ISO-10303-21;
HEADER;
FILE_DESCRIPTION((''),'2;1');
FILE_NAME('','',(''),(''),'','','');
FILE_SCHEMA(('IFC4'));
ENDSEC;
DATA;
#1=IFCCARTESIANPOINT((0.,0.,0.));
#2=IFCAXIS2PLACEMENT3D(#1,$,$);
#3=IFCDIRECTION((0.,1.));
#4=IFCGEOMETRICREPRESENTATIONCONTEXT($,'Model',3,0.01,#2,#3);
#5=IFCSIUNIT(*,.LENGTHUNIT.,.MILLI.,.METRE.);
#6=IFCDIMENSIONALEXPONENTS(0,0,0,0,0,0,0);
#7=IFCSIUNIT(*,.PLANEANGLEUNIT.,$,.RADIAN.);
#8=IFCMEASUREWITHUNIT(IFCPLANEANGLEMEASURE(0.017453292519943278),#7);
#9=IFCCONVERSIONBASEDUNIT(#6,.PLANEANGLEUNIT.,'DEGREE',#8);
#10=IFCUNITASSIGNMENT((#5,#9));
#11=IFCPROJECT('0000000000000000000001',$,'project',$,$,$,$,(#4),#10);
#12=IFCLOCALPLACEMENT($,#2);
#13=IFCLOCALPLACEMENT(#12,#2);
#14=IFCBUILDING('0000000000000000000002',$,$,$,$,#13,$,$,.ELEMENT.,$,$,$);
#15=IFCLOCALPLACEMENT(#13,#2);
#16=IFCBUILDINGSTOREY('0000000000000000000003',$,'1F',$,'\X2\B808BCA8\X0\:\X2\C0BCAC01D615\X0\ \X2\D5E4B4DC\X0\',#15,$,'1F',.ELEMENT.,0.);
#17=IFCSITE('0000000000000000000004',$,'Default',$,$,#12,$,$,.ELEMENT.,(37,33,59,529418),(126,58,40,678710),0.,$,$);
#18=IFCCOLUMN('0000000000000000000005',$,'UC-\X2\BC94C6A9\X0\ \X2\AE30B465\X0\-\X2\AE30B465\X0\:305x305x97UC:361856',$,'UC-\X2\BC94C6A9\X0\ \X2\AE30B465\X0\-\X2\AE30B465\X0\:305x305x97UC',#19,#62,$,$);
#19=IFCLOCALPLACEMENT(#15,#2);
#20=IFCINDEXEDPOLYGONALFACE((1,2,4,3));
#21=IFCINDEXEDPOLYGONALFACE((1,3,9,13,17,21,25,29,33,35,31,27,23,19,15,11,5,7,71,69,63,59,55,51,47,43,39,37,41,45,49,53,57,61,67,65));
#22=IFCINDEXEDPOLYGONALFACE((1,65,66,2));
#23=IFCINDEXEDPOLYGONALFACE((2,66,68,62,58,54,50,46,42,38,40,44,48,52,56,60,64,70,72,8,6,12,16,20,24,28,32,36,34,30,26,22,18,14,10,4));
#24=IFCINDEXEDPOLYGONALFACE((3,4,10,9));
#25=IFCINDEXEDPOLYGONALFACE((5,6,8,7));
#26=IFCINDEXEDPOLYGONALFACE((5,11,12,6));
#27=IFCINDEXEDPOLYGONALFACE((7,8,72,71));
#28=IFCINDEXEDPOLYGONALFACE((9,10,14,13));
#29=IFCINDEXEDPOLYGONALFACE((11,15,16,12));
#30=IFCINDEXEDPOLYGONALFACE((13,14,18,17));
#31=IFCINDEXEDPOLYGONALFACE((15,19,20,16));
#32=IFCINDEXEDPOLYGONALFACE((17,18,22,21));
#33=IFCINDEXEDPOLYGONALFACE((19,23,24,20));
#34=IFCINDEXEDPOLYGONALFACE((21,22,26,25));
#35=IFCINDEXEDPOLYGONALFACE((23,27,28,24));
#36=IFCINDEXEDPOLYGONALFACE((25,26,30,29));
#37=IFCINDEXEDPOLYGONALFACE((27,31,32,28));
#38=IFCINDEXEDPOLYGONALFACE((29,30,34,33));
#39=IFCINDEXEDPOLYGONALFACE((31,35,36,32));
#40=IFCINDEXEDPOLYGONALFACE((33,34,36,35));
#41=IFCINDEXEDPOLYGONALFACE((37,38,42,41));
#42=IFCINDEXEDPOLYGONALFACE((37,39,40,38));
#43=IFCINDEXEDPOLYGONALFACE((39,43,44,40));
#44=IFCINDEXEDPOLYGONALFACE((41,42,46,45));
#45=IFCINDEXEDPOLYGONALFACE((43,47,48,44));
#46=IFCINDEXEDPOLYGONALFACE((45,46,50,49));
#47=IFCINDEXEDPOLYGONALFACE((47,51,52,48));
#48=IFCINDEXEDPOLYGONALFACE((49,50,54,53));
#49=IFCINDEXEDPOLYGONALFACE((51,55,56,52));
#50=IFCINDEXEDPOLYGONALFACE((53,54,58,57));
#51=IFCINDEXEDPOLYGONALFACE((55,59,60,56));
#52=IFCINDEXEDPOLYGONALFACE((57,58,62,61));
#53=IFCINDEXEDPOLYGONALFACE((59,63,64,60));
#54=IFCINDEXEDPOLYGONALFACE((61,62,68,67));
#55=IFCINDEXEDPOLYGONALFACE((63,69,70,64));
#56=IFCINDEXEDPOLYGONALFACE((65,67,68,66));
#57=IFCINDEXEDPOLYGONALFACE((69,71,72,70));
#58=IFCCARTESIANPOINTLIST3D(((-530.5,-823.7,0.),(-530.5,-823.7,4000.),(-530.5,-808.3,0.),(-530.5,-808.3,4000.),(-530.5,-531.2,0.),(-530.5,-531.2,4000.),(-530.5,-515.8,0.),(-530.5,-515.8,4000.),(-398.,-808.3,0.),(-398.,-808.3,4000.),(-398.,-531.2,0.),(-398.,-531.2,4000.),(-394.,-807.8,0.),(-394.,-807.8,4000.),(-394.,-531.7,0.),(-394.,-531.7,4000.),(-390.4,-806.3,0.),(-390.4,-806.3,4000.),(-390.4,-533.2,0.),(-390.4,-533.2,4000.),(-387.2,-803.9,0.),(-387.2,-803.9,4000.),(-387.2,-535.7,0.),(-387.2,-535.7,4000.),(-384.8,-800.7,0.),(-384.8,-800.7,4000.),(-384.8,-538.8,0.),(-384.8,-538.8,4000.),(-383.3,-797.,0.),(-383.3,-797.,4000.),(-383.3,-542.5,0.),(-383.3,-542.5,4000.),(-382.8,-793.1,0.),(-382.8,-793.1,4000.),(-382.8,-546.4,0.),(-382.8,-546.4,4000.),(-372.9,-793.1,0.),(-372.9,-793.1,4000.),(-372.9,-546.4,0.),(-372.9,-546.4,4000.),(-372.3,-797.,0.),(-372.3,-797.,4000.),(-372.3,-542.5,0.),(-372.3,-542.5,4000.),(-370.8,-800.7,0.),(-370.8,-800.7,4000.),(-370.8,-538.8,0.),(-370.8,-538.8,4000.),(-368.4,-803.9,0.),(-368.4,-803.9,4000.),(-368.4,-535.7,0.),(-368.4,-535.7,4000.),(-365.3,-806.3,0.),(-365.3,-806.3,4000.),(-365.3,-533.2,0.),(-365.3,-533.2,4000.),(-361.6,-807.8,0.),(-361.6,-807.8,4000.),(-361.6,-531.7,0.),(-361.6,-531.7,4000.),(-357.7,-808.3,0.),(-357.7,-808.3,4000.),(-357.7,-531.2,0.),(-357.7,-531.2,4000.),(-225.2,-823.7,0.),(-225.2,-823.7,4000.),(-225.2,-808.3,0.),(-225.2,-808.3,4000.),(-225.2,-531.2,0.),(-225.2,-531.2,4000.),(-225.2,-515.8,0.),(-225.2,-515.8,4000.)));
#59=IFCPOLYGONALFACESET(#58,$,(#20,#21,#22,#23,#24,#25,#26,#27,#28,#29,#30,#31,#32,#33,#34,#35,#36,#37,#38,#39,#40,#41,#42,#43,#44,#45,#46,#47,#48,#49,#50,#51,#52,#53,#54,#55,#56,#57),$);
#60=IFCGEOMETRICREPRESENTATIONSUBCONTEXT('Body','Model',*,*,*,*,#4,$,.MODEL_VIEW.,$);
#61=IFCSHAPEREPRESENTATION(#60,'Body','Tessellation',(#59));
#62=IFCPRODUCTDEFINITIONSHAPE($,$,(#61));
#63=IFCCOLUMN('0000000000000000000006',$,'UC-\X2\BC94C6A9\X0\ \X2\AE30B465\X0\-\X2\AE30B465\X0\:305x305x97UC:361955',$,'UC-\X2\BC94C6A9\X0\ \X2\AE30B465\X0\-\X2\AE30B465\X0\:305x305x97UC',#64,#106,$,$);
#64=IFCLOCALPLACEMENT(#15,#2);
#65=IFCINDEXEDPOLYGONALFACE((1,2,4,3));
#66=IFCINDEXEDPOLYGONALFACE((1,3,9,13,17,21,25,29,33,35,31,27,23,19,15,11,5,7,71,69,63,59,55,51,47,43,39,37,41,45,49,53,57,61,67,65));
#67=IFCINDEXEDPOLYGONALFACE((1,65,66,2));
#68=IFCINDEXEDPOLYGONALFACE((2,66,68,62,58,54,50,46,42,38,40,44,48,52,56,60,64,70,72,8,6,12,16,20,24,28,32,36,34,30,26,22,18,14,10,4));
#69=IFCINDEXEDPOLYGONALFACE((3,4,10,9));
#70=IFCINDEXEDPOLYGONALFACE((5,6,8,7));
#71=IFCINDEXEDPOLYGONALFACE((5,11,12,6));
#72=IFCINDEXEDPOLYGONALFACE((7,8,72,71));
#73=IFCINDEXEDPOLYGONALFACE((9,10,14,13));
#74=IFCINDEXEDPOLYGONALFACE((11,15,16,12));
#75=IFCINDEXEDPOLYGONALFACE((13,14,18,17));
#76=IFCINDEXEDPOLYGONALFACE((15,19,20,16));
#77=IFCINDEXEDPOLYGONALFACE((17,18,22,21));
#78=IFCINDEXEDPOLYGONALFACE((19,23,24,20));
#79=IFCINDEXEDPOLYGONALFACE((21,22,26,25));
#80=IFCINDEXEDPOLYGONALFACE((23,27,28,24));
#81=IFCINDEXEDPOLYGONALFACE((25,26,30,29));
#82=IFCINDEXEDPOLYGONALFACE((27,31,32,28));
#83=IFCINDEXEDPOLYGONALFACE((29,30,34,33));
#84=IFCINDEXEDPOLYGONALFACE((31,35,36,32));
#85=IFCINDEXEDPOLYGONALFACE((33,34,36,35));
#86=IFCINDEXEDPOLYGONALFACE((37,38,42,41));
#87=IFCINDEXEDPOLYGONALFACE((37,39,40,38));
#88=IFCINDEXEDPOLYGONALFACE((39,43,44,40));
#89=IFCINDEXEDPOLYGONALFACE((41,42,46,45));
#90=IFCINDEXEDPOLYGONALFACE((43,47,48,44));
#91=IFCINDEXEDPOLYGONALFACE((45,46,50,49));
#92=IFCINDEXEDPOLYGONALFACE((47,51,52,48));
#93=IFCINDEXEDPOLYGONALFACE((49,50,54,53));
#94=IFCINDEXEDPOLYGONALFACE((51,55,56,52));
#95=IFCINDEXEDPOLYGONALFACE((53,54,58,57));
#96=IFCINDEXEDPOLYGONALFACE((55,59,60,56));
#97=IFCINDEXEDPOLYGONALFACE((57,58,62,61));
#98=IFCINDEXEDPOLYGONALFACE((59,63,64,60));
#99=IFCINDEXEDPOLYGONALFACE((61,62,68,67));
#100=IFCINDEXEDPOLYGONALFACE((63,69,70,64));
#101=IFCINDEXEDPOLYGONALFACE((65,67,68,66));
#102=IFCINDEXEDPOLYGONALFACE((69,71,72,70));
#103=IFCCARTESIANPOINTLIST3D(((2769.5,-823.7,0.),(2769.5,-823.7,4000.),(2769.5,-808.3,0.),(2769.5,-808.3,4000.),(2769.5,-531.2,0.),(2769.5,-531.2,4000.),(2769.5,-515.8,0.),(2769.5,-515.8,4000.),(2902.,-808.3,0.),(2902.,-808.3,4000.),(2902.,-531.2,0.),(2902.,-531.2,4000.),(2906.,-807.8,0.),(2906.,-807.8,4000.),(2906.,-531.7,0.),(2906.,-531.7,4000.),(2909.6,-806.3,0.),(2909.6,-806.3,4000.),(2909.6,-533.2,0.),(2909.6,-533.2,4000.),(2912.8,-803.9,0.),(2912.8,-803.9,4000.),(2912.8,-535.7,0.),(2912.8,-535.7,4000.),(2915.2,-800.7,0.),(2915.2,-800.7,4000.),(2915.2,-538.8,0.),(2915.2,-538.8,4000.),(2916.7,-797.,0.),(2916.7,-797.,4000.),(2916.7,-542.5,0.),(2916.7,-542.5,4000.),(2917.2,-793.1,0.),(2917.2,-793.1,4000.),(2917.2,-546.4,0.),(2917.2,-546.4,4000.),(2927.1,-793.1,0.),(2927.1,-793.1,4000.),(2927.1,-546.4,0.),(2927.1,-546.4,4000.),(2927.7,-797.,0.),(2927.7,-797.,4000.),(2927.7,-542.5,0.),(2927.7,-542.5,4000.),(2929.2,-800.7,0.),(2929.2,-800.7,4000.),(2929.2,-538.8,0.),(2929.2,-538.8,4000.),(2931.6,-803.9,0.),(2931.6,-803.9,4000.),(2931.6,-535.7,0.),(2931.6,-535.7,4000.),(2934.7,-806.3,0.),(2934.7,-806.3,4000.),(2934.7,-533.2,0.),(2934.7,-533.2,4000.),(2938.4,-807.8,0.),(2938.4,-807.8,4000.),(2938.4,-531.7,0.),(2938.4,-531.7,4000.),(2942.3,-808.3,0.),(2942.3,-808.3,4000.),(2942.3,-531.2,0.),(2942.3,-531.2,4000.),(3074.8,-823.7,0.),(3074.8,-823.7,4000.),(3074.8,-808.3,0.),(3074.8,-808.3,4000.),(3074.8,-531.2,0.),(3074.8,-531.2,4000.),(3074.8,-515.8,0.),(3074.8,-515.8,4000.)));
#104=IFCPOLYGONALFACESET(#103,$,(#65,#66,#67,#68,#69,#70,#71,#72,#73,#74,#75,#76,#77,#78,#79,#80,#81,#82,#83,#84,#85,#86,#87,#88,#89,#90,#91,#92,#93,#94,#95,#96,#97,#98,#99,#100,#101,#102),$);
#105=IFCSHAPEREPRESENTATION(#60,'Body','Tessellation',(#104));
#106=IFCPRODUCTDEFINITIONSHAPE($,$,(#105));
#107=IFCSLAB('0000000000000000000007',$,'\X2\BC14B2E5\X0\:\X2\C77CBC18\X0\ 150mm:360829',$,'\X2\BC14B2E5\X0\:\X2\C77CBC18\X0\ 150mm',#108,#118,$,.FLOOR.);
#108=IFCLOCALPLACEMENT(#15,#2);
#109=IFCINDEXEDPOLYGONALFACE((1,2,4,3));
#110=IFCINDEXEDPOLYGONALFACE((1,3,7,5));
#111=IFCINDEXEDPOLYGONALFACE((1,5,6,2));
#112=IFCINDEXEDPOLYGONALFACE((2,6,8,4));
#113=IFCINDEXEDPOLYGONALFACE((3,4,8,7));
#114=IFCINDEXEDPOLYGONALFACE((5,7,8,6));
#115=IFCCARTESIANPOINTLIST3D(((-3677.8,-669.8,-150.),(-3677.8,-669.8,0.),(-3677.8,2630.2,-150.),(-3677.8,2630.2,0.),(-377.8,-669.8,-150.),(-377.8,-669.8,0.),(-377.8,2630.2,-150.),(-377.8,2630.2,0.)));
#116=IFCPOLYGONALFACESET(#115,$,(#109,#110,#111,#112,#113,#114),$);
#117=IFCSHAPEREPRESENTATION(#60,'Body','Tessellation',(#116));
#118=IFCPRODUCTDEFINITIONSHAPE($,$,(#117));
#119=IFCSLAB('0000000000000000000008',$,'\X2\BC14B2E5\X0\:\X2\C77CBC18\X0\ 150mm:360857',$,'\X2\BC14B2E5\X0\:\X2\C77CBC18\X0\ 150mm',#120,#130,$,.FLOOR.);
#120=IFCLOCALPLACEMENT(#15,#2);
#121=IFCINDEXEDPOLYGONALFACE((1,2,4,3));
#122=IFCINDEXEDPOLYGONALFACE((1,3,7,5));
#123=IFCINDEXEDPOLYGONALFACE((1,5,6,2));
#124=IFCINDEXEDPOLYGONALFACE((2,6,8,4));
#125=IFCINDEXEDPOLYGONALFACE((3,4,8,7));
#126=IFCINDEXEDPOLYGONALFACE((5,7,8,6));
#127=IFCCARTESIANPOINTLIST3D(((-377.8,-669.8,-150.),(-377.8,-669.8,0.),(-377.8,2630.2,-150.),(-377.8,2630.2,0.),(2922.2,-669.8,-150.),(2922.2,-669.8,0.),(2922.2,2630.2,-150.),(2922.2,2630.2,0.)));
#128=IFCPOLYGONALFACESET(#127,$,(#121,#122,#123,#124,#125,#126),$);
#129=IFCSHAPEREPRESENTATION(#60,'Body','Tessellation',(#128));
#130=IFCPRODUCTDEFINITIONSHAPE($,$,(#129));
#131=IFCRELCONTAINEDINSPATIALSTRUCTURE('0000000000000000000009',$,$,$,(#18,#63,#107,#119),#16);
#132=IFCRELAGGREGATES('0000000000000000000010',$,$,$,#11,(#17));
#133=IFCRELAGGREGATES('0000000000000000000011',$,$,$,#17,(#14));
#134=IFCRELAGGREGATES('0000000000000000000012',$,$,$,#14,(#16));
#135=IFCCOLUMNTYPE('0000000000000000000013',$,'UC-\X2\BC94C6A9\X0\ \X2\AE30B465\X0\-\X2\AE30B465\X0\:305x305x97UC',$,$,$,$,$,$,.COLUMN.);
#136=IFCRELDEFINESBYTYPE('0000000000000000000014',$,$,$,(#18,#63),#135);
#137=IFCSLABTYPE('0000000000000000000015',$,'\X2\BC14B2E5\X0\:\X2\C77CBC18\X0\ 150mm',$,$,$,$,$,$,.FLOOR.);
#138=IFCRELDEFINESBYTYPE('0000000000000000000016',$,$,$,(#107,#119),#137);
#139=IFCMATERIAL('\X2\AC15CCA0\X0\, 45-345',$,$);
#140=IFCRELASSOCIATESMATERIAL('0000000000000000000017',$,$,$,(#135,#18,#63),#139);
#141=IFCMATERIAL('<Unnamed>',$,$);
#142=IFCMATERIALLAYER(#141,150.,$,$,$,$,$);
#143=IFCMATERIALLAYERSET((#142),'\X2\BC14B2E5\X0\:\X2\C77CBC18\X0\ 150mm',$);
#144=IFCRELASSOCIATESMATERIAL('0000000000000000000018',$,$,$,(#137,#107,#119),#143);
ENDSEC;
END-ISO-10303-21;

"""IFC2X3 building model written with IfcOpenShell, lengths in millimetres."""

from ifc_helpers import new_model, entity, si_unit, converted_unit, direction, frame, origin, origin_2d_with_axis, place, context, subcontext, project, spatial, rectangle, i_section, extrude, source, transform, mapped, material, layer, layer_set, layer_usage, type_object, type_shapes, element, save


model = new_model("IFC2X3")

# Units and contexts
model_context = context("Model", 3, precision=0.01, world=origin(), true_north=direction((0.0, 1.0)))
body_context = subcontext(model_context, "Body", "Model", "MODEL_VIEW")
ifc_project = project(units=[si_unit("LENGTHUNIT", "METRE", prefix="MILLI"), converted_unit("PLANEANGLEUNIT", "DEGREE", entity("IfcPlaneAngleMeasure", 0.017453292519943278), si_unit("PLANEANGLEUNIT", "RADIAN"), dimensions=[0, 0, 0, 0, 0, 0, 0])], contexts=[model_context])

# Site, building, storey
site_placement = place(None, origin())
site = spatial("IfcSite", under=ifc_project, at=site_placement, Name="Default", CompositionType="ELEMENT", RefLatitude=(37, 33, 59, 529418), RefLongitude=(126, 58, 40, 678710), RefElevation=0.0)
building_placement = place(site_placement, origin())
building = spatial("IfcBuilding", under=site, at=building_placement, CompositionType="ELEMENT")
storey_placement = place(building_placement, origin())
storey = spatial("IfcBuildingStorey", under=building, at=storey_placement, Name="1F", ObjectType="레벨:삼각형 헤드", LongName="1F", CompositionType="ELEMENT", Elevation=0.0)

# Columns
ifc_material_1 = material(Name="강철, 45-345")
column_type = type_object("IfcColumnType", Name="UC-범용 기둥-기둥:305x305x97UC", PredefinedType="COLUMN", material=ifc_material_1)
shared_shape = source(origin(), body_context, "Body", "SweptSolid", [
    extrude(i_section(OverallWidth=305.3, OverallDepth=307.9, WebThickness=9.9, FlangeThickness=15.4, FilletRadius=15.2, at=origin_2d_with_axis()), frame((0.0, 0.0, 0.0), z_axis=(0.0, 0.0, 1.0), x_axis=(-1.0, 0.0, 0.0)), (0.0, 0.0, 1.0), 4000.0),
])
type_shapes(column_type, [shared_shape])
for number, where, name in (
    (1, (-377.8, -669.8, 0.0), "UC-범용 기둥-기둥:305x305x97UC:361856"),
    (2, (2922.2, -669.8, 0.0), "UC-범용 기둥-기둥:305x305x97UC:361955"),
):
    element("IfcColumn", number, at=place(storey_placement, frame(where)), inside=storey, type_object=column_type, material=ifc_material_1, Name=name, ObjectType="UC-범용 기둥-기둥:305x305x97UC", context=body_context, shape_type="MappedRepresentation", body=[
        mapped(shared_shape, transform((0.0, 0.0, 0.0), scale=1.0)),
    ])

# Slabs
ifc_material_2 = material(Name="<Unnamed>")
ifc_layer = layer(ifc_material_2, 150.0)
ifc_layer_set = layer_set([ifc_layer], Name="바닥:일반 150mm")
ifc_layer_usage = layer_usage(ifc_layer_set, "AXIS3", "POSITIVE", 0.0)
slab_type = type_object("IfcSlabType", Name="바닥:일반 150mm", PredefinedType="FLOOR", material=ifc_layer_set)
slab_1_placement = place(storey_placement, origin())
element("IfcSlab", 3, at=slab_1_placement, inside=storey, type_object=slab_type, material=ifc_layer_usage, Name="바닥:일반 150mm:360829", ObjectType="바닥:일반 150mm", PredefinedType="FLOOR", context=body_context, shape_type="SweptSolid", body=[
    extrude(rectangle(XDim=3300.0, YDim=3300.0, at=origin_2d_with_axis()), frame((-2027.8, 980.2, 0.0), z_axis=(0.0, 0.0, -1.0), x_axis=(0.0, 1.0, 0.0)), (0.0, 0.0, 1.0), 150.0),
])
slab_2_placement = place(storey_placement, origin())
element("IfcSlab", 4, at=slab_2_placement, inside=storey, type_object=slab_type, material=ifc_layer_usage, Name="바닥:일반 150mm:360857", ObjectType="바닥:일반 150mm", PredefinedType="FLOOR", context=body_context, shape_type="SweptSolid", body=[
    extrude(rectangle(XDim=3300.0, YDim=3300.0, at=origin_2d_with_axis()), frame((1272.2, 980.2, 0.0), z_axis=(0.0, 0.0, -1.0), x_axis=(0.0, 1.0, 0.0)), (0.0, 0.0, 1.0), 150.0),
])

save(model, "model.ifc")
